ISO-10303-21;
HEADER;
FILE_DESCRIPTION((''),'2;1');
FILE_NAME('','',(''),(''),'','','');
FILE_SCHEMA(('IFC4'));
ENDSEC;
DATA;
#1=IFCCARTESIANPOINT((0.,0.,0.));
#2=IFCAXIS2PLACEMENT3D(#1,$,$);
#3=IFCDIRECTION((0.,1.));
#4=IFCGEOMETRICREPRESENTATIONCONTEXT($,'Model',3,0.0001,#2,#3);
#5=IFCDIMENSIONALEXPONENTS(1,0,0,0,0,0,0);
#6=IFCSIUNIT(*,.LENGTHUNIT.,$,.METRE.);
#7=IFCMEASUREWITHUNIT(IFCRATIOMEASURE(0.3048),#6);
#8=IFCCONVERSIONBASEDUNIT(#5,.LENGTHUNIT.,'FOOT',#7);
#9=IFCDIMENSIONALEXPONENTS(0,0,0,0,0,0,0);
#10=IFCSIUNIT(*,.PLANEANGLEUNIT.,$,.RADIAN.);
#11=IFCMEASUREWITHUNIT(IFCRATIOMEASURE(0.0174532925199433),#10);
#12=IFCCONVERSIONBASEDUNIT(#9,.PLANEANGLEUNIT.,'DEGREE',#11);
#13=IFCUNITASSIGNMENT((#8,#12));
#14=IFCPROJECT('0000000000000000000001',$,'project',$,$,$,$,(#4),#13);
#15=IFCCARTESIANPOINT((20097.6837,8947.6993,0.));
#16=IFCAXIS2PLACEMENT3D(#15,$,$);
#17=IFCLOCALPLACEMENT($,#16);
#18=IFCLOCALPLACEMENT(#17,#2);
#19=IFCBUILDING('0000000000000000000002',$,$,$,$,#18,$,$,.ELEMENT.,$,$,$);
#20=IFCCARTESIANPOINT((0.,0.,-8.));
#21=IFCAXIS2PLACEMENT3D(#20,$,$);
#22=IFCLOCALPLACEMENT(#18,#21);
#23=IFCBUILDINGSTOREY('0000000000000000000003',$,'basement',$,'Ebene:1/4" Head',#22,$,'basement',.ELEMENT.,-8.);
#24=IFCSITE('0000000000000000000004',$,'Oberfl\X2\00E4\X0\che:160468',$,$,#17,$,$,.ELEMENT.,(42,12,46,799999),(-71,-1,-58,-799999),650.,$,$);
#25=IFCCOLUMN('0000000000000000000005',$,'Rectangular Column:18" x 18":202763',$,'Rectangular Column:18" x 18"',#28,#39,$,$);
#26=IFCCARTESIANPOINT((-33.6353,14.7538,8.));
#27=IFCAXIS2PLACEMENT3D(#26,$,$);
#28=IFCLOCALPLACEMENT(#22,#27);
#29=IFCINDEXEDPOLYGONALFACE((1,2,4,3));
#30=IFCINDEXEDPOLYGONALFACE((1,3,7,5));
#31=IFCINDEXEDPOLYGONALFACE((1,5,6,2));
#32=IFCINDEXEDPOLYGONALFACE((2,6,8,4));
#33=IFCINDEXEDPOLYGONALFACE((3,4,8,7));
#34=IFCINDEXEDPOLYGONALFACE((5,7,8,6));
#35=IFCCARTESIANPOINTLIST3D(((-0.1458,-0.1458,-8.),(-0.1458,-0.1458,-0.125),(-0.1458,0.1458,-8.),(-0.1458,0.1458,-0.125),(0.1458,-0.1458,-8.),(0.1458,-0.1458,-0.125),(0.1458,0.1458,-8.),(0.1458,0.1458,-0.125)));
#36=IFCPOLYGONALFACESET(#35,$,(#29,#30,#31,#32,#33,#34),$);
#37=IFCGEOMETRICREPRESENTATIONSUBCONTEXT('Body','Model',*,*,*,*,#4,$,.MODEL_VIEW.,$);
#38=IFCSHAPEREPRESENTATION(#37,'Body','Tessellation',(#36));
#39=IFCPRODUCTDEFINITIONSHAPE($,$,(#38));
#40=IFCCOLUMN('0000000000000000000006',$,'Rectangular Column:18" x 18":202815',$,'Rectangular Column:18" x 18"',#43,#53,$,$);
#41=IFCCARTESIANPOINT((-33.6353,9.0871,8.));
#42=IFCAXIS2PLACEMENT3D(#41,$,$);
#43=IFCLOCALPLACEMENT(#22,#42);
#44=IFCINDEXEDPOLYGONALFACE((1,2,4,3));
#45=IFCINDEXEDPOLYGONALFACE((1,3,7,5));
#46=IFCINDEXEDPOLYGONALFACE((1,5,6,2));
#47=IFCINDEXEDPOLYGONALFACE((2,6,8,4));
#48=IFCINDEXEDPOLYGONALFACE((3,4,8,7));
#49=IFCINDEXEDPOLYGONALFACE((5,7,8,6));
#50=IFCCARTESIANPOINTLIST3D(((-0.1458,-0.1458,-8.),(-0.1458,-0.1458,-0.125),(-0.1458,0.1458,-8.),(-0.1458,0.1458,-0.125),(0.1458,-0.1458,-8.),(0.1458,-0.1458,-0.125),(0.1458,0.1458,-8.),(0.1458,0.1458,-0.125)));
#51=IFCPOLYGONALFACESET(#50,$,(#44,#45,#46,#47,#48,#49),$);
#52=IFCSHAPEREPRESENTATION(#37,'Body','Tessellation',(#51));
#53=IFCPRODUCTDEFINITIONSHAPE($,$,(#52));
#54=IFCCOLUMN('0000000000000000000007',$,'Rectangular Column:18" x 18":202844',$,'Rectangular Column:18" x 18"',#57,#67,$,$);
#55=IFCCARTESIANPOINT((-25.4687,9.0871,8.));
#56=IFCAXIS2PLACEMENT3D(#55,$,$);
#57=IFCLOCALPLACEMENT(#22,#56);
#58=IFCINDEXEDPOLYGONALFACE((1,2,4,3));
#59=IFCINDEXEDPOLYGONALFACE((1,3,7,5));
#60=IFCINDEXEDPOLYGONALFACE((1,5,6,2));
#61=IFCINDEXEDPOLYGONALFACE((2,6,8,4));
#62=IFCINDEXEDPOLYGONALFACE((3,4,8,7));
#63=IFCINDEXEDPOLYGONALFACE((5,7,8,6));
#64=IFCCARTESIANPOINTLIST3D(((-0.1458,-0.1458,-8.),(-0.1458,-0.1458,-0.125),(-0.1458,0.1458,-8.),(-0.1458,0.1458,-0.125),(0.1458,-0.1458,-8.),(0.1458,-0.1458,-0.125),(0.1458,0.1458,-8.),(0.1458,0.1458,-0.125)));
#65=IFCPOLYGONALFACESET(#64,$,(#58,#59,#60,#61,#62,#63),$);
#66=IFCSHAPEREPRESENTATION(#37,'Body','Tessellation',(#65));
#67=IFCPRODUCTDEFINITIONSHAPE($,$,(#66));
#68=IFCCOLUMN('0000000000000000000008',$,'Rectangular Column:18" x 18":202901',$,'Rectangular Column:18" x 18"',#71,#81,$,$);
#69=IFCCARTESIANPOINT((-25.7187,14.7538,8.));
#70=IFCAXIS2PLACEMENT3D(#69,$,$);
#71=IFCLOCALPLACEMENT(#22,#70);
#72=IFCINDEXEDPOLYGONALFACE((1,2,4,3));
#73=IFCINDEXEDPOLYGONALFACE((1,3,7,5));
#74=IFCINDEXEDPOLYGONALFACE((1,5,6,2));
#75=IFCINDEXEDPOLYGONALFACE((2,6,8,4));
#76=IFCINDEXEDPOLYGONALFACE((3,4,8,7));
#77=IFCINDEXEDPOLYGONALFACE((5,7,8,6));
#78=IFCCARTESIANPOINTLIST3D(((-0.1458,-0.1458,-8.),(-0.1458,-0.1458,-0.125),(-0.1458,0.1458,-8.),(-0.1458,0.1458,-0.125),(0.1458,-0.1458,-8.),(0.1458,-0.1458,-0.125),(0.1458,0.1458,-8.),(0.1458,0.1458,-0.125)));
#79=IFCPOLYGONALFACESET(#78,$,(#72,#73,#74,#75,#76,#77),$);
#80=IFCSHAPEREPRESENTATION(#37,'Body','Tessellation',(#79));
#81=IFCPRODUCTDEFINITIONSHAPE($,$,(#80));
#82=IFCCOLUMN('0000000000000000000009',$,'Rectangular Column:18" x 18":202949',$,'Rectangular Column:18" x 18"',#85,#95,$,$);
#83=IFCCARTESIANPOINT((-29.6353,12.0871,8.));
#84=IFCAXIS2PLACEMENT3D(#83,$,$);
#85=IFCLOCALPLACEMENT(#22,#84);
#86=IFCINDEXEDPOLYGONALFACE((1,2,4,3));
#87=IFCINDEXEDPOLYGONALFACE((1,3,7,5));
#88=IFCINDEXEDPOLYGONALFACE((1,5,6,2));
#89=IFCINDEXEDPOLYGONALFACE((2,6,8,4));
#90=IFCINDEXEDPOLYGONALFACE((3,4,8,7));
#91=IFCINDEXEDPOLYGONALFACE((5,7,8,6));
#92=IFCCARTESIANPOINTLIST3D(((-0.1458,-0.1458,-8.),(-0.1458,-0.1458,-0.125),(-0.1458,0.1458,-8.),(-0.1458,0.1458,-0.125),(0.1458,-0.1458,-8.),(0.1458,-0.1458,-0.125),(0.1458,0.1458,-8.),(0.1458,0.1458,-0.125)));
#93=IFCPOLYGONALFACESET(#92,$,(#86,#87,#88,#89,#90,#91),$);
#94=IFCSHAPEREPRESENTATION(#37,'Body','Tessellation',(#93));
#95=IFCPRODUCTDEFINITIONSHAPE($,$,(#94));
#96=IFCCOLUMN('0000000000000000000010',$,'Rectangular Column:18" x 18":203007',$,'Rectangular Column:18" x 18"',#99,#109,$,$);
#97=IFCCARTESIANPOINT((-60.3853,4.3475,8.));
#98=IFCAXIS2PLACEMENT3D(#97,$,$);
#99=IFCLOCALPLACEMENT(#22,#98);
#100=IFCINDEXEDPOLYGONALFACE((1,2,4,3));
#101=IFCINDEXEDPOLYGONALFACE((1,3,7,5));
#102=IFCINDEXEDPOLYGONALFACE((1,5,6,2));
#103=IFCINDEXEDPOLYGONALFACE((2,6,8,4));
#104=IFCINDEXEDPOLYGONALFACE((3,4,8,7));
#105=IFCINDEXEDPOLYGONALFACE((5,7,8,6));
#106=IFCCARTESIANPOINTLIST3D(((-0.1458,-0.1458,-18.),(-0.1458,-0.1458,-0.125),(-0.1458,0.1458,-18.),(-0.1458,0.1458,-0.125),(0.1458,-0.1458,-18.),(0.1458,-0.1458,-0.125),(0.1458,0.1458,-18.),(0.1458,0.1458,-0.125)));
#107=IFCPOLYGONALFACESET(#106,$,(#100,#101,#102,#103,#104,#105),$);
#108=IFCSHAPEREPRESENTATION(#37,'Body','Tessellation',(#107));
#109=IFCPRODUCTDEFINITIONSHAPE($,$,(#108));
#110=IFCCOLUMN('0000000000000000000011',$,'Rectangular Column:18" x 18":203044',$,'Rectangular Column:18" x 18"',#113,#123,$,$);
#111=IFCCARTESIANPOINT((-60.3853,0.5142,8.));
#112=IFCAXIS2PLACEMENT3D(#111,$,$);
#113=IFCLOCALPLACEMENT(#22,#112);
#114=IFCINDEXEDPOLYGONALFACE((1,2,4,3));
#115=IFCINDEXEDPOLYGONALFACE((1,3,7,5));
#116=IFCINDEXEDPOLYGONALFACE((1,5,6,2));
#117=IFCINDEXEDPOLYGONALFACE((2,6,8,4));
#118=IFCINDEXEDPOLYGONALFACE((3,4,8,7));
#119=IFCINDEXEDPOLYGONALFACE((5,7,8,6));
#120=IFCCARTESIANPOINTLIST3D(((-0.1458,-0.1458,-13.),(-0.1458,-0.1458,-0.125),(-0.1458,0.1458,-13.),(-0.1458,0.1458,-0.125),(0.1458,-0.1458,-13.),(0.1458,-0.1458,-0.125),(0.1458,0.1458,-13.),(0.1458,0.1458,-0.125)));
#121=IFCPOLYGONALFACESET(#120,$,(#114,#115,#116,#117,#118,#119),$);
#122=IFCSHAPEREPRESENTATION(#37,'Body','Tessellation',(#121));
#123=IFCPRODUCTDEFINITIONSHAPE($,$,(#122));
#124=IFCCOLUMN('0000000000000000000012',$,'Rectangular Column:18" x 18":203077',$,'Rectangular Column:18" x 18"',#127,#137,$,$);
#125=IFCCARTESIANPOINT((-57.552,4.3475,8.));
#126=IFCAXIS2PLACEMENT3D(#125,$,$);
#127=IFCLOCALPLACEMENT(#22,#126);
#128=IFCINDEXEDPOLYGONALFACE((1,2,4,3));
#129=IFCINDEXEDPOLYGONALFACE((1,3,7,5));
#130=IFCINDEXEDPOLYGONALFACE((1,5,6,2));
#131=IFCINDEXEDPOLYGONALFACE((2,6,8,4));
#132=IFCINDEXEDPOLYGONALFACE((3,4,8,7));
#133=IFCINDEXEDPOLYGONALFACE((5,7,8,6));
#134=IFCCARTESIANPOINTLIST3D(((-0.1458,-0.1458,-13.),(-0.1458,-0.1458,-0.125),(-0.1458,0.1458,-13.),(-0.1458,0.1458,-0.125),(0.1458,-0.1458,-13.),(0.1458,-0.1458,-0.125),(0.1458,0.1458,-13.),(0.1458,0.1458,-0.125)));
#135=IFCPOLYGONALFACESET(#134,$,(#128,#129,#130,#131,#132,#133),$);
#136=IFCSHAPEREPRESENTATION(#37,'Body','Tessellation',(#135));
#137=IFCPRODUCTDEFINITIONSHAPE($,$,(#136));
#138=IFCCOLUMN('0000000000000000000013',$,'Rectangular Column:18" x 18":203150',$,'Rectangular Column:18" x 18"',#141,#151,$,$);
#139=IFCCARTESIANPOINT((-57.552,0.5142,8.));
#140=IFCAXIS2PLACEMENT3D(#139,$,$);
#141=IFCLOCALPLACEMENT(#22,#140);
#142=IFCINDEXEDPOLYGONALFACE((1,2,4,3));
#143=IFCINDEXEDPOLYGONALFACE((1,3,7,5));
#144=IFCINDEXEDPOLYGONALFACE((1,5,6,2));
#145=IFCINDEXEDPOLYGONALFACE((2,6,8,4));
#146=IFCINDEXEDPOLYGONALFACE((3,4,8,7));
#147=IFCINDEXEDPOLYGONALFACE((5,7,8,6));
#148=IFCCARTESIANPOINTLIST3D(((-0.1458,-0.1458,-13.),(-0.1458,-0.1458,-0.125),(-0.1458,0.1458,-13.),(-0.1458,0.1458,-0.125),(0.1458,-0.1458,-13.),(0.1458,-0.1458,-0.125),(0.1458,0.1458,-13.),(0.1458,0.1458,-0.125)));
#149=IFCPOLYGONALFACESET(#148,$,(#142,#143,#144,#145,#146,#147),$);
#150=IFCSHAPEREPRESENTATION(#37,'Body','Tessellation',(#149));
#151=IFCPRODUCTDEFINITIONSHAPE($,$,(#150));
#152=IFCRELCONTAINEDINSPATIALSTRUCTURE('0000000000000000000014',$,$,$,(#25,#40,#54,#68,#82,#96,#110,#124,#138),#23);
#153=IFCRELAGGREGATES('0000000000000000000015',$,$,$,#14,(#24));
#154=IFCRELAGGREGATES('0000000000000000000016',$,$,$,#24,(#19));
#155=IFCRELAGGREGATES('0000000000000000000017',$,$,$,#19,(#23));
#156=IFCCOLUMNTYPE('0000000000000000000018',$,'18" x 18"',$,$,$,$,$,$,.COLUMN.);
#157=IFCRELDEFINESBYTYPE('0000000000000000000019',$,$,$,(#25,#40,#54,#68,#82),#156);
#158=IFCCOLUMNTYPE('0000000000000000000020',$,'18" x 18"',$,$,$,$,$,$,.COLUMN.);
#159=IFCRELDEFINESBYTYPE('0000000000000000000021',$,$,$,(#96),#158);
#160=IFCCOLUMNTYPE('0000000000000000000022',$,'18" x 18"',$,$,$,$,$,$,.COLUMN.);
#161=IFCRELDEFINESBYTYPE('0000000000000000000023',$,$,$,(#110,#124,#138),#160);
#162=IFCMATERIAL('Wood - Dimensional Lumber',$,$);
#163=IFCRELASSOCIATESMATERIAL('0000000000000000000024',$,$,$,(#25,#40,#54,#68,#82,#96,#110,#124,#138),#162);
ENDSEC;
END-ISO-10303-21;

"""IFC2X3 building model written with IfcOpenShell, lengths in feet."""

from ifc_helpers import new_model, entity, si_unit, converted_unit, direction, frame, origin, origin_2d_with_axis, place, context, subcontext, project, spatial, rectangle, extrude, source, transform, mapped, material, type_object, type_shapes, element, save


model = new_model("IFC2X3")

# Units and contexts
model_context = context("Model", 3, precision=0.0001, world=origin(), true_north=direction((0.0, 1.0)))
body_context = subcontext(model_context, "Body", "Model", "MODEL_VIEW")
ifc_project = project(units=[converted_unit("LENGTHUNIT", "FOOT", entity("IfcRatioMeasure", 0.3048), si_unit("LENGTHUNIT", "METRE"), dimensions=[1, 0, 0, 0, 0, 0, 0]), converted_unit("PLANEANGLEUNIT", "DEGREE", entity("IfcRatioMeasure", 0.0174532925199433), si_unit("PLANEANGLEUNIT", "RADIAN"), dimensions=[0, 0, 0, 0, 0, 0, 0])], contexts=[model_context])

# Site, building, storey
site_placement = place(None, frame((20097.6837, 8947.6993, 0.0)))
site = spatial("IfcSite", under=ifc_project, at=site_placement, Name="Oberfläche:160468", CompositionType="ELEMENT", RefLatitude=(42, 12, 46, 799999), RefLongitude=(-71, -1, -58, -799999), RefElevation=650.0)
building_placement = place(site_placement, origin())
building = spatial("IfcBuilding", under=site, at=building_placement, CompositionType="ELEMENT")
storey_placement = place(building_placement, frame((0.0, 0.0, -8.0)))
storey = spatial("IfcBuildingStorey", under=building, at=storey_placement, Name="basement", ObjectType="Ebene:1/4\" Head", LongName="basement", CompositionType="ELEMENT", Elevation=-8.0)

# Columns
ifc_material_1 = material(Name="Wood - Dimensional Lumber")
column_type_1 = type_object("IfcColumnType", Name="18\" x 18\"", PredefinedType="COLUMN")
shared_shape_1 = source(origin(), body_context, "Body", "SweptSolid", [
    extrude(rectangle(XDim=0.2917, YDim=0.2917, at=origin_2d_with_axis()), frame((0.0, 0.0, -8.0), z_axis=(0.0, 0.0, 1.0), x_axis=(0.0, -1.0, 0.0)), (0.0, 0.0, 1.0), 7.875),
])
type_shapes(column_type_1, [shared_shape_1])
for number, where, name in (
    (1, (-33.6353, 14.7538, 8.0), "Rectangular Column:18\" x 18\":202763"),
    (2, (-33.6353, 9.0871, 8.0), "Rectangular Column:18\" x 18\":202815"),
    (3, (-25.4687, 9.0871, 8.0), "Rectangular Column:18\" x 18\":202844"),
    (4, (-25.7187, 14.7538, 8.0), "Rectangular Column:18\" x 18\":202901"),
    (5, (-29.6353, 12.0871, 8.0), "Rectangular Column:18\" x 18\":202949"),
):
    element("IfcColumn", number, at=place(storey_placement, frame(where)), inside=storey, type_object=column_type_1, material=ifc_material_1, Name=name, ObjectType="Rectangular Column:18\" x 18\"", context=body_context, shape_type="MappedRepresentation", body=[
        mapped(shared_shape_1, transform((0.0, 0.0, 0.0), scale=1.0)),
    ])
column_type_2 = type_object("IfcColumnType", Name="18\" x 18\"", PredefinedType="COLUMN")
shared_shape_2 = source(origin(), body_context, "Body", "SweptSolid", [
    extrude(rectangle(XDim=0.2917, YDim=0.2917, at=origin_2d_with_axis()), frame((0.0, 0.0, -18.0), z_axis=(0.0, 0.0, 1.0), x_axis=(0.0, -1.0, 0.0)), (0.0, 0.0, 1.0), 17.875),
])
type_shapes(column_type_2, [shared_shape_2])
column_placement = place(storey_placement, frame((-60.3853, 4.3475, 8.0)))
element("IfcColumn", 6, at=column_placement, inside=storey, type_object=column_type_2, material=ifc_material_1, Name="Rectangular Column:18\" x 18\":203007", ObjectType="Rectangular Column:18\" x 18\"", context=body_context, shape_type="MappedRepresentation", body=[
    mapped(shared_shape_2, transform((0.0, 0.0, 0.0), scale=1.0)),
])
column_type_3 = type_object("IfcColumnType", Name="18\" x 18\"", PredefinedType="COLUMN")
shared_shape_3 = source(origin(), body_context, "Body", "SweptSolid", [
    extrude(rectangle(XDim=0.2917, YDim=0.2917, at=origin_2d_with_axis()), frame((0.0, 0.0, -13.0), z_axis=(0.0, 0.0, 1.0), x_axis=(0.0, -1.0, 0.0)), (0.0, 0.0, 1.0), 12.875),
])
type_shapes(column_type_3, [shared_shape_3])
for number, where, name in (
    (7, (-60.3853, 0.5142, 8.0), "Rectangular Column:18\" x 18\":203044"),
    (8, (-57.552, 4.3475, 8.0), "Rectangular Column:18\" x 18\":203077"),
    (9, (-57.552, 0.5142, 8.0), "Rectangular Column:18\" x 18\":203150"),
):
    element("IfcColumn", number, at=place(storey_placement, frame(where)), inside=storey, type_object=column_type_3, material=ifc_material_1, Name=name, ObjectType="Rectangular Column:18\" x 18\"", context=body_context, shape_type="MappedRepresentation", body=[
        mapped(shared_shape_3, transform((0.0, 0.0, 0.0), scale=1.0)),
    ])

save(model, "model.ifc")
